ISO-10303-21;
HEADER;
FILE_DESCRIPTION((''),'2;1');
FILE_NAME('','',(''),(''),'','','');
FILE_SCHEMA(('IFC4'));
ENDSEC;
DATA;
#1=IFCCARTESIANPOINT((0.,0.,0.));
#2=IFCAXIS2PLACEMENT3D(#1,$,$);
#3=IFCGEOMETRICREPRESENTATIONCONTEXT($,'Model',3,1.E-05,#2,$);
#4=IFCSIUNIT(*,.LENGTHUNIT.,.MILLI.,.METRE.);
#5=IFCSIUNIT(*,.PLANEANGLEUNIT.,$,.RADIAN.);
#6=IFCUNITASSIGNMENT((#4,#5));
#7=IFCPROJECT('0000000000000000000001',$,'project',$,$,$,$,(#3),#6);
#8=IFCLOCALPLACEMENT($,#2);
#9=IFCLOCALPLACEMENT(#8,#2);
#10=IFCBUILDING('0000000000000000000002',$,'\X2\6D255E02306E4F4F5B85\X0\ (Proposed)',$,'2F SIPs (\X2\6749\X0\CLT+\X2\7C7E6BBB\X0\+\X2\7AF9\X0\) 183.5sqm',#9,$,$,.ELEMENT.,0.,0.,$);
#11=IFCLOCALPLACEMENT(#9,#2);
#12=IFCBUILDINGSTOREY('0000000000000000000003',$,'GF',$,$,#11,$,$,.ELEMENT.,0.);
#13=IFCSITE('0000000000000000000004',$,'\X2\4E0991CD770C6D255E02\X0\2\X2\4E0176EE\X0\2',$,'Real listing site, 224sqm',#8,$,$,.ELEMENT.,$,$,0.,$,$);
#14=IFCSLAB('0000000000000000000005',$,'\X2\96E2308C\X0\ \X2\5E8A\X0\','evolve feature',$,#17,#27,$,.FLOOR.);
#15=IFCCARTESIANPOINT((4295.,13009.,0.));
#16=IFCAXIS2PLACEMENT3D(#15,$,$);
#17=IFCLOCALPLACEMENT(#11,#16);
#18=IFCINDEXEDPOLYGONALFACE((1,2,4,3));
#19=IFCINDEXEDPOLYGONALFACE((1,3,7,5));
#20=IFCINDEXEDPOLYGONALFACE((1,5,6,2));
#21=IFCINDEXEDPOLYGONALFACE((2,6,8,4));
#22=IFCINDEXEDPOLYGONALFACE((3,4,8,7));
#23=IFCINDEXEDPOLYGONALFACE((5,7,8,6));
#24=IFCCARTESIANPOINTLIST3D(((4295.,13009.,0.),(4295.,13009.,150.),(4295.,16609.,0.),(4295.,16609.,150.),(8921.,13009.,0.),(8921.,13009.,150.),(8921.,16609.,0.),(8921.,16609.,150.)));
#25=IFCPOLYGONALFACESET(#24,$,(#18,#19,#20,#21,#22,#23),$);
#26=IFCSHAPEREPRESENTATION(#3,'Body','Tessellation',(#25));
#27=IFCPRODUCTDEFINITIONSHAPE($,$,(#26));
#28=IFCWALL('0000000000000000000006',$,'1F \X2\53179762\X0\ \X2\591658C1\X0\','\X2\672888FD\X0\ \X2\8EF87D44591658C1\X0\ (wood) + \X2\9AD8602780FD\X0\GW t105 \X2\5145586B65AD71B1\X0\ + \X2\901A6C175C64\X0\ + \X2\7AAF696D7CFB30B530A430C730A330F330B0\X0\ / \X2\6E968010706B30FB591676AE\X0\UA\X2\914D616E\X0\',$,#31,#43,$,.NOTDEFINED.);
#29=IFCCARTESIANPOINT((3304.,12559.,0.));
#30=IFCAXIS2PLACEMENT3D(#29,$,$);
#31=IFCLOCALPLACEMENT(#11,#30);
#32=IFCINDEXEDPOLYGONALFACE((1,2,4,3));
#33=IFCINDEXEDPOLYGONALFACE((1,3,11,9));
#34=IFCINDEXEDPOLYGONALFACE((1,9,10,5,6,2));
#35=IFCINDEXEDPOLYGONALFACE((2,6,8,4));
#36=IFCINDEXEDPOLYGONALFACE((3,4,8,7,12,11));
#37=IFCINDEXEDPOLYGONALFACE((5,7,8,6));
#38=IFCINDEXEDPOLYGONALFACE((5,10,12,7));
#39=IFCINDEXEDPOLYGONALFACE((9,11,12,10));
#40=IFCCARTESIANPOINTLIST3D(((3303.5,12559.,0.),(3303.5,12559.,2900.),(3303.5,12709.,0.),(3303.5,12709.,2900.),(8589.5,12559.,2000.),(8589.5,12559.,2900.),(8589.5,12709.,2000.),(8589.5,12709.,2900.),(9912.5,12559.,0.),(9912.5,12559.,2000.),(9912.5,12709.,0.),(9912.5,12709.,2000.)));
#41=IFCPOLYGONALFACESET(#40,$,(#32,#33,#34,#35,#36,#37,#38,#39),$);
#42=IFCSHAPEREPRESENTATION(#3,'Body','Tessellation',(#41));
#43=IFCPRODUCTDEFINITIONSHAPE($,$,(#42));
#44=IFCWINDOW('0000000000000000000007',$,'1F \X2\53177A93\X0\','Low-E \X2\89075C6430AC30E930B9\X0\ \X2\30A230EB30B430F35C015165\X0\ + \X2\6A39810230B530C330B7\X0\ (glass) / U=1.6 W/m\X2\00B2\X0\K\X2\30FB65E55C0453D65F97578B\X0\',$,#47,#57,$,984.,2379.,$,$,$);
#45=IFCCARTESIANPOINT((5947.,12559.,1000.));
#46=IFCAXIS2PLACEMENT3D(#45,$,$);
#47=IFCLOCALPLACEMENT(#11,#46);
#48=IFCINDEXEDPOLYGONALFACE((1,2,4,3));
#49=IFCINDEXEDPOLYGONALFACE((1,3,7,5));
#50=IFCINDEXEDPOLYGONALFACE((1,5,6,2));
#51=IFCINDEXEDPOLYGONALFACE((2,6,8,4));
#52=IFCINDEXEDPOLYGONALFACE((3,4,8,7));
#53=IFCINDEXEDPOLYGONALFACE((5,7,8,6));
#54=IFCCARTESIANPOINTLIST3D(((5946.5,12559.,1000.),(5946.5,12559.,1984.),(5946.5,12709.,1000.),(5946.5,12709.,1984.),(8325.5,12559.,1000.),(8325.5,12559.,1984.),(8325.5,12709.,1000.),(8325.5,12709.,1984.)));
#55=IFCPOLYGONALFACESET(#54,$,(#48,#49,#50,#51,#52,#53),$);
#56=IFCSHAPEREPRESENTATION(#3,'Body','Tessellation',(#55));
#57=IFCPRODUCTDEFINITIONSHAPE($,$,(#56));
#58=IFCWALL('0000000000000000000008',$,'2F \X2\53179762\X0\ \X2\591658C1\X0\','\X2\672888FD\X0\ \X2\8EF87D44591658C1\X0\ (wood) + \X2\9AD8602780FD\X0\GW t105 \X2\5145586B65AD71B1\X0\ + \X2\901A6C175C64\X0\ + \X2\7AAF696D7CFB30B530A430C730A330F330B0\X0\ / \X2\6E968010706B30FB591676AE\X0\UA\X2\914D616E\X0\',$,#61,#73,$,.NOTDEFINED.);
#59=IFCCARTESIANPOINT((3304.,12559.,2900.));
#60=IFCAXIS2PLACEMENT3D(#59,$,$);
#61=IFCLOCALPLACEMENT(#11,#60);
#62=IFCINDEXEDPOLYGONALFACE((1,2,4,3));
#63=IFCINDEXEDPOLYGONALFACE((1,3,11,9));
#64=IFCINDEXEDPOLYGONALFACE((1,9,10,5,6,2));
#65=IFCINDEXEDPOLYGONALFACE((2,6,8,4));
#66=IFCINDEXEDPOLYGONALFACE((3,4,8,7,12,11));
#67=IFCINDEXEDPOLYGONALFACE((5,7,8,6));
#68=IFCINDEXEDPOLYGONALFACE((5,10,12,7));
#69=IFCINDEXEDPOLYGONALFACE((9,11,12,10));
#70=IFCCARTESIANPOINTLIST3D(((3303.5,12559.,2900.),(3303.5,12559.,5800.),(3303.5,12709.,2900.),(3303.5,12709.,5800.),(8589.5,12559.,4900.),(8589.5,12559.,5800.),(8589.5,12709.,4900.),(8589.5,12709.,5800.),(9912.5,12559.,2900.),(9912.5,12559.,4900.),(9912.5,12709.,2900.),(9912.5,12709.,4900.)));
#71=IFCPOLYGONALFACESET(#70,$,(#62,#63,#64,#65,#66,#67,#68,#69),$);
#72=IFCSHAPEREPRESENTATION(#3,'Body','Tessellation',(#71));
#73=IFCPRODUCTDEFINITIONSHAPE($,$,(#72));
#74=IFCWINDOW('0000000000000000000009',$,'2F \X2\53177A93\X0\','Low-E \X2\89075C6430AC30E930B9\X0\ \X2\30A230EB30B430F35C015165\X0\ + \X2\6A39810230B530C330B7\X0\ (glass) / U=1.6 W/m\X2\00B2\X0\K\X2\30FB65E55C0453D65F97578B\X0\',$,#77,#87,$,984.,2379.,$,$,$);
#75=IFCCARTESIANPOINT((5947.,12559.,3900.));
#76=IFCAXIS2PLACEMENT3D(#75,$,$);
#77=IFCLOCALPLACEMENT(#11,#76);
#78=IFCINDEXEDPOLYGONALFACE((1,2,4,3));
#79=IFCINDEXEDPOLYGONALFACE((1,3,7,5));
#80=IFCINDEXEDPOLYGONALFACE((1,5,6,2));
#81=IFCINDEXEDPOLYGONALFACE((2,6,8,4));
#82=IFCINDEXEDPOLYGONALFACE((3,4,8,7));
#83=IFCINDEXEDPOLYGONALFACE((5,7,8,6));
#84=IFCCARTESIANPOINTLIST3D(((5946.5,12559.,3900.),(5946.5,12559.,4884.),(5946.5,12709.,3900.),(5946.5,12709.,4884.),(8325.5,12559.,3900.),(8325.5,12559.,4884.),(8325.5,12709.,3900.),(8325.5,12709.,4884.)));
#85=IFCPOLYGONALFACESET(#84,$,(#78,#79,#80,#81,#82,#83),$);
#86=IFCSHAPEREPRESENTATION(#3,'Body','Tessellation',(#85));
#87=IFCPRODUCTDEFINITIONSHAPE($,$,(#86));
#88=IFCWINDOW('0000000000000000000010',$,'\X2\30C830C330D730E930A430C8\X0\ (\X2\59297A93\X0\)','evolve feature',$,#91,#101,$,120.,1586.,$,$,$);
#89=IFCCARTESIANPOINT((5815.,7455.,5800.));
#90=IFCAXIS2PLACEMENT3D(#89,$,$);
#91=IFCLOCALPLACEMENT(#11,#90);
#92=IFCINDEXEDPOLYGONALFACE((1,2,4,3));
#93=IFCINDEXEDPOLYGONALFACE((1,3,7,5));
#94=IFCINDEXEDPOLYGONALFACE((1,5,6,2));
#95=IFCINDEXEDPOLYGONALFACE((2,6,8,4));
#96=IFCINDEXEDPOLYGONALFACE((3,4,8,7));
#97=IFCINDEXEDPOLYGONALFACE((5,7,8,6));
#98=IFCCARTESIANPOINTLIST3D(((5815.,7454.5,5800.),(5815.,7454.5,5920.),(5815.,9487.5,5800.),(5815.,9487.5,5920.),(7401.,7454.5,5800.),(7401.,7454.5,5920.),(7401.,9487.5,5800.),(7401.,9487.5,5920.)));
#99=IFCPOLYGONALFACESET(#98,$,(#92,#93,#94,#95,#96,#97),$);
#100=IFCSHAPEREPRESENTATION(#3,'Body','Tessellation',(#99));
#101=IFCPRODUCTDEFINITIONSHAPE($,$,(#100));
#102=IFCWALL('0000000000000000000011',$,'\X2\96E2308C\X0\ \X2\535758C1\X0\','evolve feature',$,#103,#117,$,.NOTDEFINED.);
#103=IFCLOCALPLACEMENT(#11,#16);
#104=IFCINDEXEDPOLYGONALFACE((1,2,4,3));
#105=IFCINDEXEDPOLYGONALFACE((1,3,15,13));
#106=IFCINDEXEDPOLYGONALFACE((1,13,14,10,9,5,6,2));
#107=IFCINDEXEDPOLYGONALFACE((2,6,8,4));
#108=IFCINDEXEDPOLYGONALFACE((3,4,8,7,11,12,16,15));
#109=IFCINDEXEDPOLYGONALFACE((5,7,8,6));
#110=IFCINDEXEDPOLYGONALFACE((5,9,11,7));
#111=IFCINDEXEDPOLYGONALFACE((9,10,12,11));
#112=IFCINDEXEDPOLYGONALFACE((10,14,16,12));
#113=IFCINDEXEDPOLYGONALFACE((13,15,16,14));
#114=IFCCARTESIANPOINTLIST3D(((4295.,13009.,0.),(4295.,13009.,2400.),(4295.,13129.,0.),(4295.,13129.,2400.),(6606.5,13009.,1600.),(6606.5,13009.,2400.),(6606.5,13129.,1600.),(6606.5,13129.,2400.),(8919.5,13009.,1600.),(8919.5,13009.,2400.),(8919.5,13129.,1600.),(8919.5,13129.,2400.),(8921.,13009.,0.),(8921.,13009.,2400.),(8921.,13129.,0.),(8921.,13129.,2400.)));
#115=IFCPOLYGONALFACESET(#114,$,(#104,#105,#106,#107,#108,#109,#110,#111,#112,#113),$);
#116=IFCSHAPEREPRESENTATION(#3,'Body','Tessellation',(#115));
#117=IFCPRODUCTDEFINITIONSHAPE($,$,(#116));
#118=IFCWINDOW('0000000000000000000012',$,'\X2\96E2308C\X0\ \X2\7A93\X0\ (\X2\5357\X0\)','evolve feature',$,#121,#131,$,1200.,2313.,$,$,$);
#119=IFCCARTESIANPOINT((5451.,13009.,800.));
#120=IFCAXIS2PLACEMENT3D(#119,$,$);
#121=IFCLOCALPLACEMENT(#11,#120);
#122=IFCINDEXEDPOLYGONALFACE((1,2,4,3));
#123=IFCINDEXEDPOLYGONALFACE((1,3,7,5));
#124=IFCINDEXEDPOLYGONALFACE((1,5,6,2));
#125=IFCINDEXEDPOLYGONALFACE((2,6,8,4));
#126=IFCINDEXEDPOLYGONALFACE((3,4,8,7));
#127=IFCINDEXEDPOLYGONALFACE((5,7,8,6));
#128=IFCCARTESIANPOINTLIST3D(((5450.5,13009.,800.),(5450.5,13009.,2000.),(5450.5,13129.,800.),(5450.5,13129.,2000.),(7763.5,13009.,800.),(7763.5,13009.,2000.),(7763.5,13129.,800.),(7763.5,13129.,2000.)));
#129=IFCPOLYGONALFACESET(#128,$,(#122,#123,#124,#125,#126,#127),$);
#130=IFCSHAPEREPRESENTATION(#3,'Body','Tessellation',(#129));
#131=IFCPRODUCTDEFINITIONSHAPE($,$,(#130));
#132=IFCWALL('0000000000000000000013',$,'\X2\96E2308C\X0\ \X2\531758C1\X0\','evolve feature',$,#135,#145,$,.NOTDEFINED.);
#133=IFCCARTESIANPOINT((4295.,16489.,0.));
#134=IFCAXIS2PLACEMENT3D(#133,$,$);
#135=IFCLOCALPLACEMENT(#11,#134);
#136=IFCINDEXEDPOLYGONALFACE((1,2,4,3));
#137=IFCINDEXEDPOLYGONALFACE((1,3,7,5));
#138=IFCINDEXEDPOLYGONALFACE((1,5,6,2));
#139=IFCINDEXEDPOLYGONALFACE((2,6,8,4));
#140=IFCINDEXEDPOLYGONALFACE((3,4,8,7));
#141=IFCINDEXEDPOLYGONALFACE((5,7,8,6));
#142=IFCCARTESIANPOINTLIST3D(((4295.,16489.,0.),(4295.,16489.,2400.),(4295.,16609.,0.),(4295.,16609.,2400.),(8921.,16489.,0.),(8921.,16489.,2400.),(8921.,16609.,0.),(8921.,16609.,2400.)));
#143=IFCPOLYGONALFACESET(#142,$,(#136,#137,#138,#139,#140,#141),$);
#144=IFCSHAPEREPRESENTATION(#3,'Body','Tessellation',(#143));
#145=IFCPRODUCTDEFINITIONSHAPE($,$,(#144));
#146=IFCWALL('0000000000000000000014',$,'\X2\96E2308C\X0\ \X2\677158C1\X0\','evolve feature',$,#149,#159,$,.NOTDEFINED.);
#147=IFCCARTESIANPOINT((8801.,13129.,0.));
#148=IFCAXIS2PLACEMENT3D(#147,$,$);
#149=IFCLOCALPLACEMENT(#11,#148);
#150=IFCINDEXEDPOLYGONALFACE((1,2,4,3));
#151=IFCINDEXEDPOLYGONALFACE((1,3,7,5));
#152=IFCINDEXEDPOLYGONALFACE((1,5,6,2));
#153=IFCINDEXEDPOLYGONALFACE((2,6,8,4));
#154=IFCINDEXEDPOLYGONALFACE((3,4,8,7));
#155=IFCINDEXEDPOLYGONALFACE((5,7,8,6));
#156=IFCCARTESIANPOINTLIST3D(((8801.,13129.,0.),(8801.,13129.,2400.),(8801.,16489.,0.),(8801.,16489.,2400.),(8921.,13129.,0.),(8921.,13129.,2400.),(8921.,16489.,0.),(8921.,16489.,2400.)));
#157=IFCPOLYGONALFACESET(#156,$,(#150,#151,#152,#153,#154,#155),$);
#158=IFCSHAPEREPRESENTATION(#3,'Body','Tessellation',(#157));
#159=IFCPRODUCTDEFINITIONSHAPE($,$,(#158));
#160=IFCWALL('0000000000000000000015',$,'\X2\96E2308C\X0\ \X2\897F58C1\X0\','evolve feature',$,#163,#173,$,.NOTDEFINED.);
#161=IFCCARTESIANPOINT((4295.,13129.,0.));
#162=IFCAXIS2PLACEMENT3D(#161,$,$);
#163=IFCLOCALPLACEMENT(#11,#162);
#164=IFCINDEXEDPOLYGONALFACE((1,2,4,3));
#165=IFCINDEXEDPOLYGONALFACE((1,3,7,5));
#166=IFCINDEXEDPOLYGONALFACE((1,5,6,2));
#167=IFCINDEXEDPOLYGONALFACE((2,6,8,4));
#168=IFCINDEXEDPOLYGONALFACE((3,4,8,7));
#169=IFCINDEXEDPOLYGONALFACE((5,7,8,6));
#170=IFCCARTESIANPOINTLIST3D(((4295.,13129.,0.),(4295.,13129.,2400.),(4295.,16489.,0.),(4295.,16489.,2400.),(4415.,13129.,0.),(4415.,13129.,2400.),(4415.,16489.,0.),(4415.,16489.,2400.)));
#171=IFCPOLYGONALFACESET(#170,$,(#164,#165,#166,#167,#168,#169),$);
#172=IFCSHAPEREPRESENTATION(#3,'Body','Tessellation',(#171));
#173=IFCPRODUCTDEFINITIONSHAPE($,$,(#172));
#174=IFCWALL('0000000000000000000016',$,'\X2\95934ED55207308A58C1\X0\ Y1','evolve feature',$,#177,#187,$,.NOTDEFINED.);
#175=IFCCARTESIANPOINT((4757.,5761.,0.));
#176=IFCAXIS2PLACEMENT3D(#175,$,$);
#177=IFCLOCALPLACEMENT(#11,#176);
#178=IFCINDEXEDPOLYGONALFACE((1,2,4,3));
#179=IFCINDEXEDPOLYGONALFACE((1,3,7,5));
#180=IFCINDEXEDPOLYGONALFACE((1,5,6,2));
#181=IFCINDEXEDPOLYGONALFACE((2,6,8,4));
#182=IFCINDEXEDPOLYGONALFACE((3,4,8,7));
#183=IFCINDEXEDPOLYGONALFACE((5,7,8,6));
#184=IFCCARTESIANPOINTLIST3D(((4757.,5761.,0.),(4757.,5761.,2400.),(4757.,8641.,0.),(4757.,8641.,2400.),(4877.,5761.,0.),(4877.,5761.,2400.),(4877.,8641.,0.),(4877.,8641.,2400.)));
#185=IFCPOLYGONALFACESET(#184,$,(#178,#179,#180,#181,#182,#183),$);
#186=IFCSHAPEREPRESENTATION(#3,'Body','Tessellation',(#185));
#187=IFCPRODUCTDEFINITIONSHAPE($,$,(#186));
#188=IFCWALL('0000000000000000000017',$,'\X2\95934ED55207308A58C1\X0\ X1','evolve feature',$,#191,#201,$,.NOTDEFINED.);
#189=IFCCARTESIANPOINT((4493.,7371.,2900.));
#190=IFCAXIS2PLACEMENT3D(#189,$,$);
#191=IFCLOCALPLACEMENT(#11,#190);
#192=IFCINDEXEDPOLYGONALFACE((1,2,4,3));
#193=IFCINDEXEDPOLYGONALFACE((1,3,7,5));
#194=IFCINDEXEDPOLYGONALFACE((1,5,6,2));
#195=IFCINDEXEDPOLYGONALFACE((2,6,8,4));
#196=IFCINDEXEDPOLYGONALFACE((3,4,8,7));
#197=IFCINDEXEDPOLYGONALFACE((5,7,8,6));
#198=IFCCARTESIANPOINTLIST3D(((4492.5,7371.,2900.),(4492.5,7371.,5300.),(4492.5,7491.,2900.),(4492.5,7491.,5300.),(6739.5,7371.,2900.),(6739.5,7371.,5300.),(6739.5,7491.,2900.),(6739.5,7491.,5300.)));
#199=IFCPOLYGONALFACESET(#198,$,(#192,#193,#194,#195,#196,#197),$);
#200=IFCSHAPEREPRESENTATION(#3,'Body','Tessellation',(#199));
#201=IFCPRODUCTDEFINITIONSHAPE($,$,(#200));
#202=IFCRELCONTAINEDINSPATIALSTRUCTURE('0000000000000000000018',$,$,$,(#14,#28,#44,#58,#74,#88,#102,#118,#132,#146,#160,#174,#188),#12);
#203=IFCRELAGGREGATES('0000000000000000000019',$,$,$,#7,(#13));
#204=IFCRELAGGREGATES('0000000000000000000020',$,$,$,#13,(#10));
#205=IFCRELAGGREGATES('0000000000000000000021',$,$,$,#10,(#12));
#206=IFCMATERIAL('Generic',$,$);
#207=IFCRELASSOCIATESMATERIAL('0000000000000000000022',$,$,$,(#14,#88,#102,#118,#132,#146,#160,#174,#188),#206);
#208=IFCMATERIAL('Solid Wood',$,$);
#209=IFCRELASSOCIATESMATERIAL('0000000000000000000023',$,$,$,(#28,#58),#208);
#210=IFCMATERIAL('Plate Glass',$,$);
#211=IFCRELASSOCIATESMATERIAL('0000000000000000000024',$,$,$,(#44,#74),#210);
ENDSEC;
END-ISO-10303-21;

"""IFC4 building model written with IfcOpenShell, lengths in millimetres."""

from ifc_helpers import new_model, si_unit, frame, frame_2d, origin, place, context, project, spatial, rectangle, extrude, material, element, fill, save


model = new_model("IFC4")

# Units and contexts
model_context = context("Model", 3, precision=1e-05, world=origin())
ifc_project = project(units=[si_unit("LENGTHUNIT", "METRE", prefix="MILLI"), si_unit("PLANEANGLEUNIT", "RADIAN")], contexts=[model_context])

# Site, building, storey
site_placement = place(None, origin())
site = spatial("IfcSite", under=ifc_project, at=site_placement, Name="三重県津市2丁目2", ObjectType="Real listing site, 224sqm", CompositionType="ELEMENT", RefElevation=0.0)
building_placement = place(site_placement, origin())
building = spatial("IfcBuilding", under=site, at=building_placement, Name="津市の住宅 (Proposed)", ObjectType="2F SIPs (杉CLT+籾殻+竹) 183.5sqm", CompositionType="ELEMENT", ElevationOfRefHeight=0.0, ElevationOfTerrain=0.0)
storey_placement = place(building_placement, origin())
storey = spatial("IfcBuildingStorey", under=building, at=storey_placement, Name="GF", CompositionType="ELEMENT", Elevation=0.0)

# Slab
ifc_material_1 = material(Name="Generic")
slab_placement = place(storey_placement, frame((4295.0, 13009.0, 0.0)))
element("IfcSlab", 1, at=slab_placement, inside=storey, material=ifc_material_1, Name="離れ 床", Description="evolve feature", PredefinedType="FLOOR", context=model_context, shape_type="SweptSolid", body=[
    extrude(rectangle(XDim=4626.0, YDim=3600.0, at=frame_2d((2313.0, 1800.0))), frame((4295.0, 13009.0, 0.0)), (0.0, 0.0, 1.0), 150.0),
])

# Wall, opening, window
ifc_material_2 = material(Name="Solid Wood")
wall_1_placement = place(storey_placement, frame((3304.0, 12559.0, 0.0)))
wall_1 = element("IfcWall", 2, at=wall_1_placement, inside=storey, material=ifc_material_2, Name="1F 北面 外壁", Description="木製 軸組外壁 (wood) + 高性能GW t105 充填断熱 + 通気層 + 窯業系サイディング / 準耐火・外皮UA配慮", PredefinedType="NOTDEFINED", context=model_context, shape_type="SweptSolid", body=[
    extrude(rectangle(XDim=6609.0, YDim=150.0, at=frame_2d((3304.0, 75.0))), frame((3304.0, 12559.0, 0.0)), (0.0, 0.0, 1.0), 2900.0),
])
opening_1_placement = place(storey_placement, frame((5947.0, 12559.0, 1000.0)))
opening_1 = element("IfcOpeningElement", 3, at=opening_1_placement, cuts=wall_1, PredefinedType="NOTDEFINED", context=model_context, shape_type="SweptSolid", body=[
    extrude(rectangle(XDim=2379.0, YDim=150.0, at=frame_2d((1189.0, 75.0))), frame((5947.0, 12559.0, 1000.0)), (0.0, 0.0, 1.0), 984.0),
])
ifc_material_3 = material(Name="Plate Glass")
window_1_placement = place(storey_placement, frame((5947.0, 12559.0, 1000.0)))
window_1 = element("IfcWindow", 4, at=window_1_placement, inside=storey, material=ifc_material_3, Name="1F 北窓", Description="Low-E 複層ガラス アルゴン封入 + 樹脂サッシ (glass) / U=1.6 W/m²K・日射取得型", OverallHeight=984.0, OverallWidth=2379.0, context=model_context, shape_type="SweptSolid", body=[
    extrude(rectangle(XDim=2379.0, YDim=150.0, at=frame_2d((1189.0, 75.0))), frame((5947.0, 12559.0, 1000.0)), (0.0, 0.0, 1.0), 984.0),
])
fill(opening_1, window_1)

# Wall, opening, window
wall_2_placement = place(storey_placement, frame((3304.0, 12559.0, 2900.0)))
wall_2 = element("IfcWall", 5, at=wall_2_placement, inside=storey, material=ifc_material_2, Name="2F 北面 外壁", Description="木製 軸組外壁 (wood) + 高性能GW t105 充填断熱 + 通気層 + 窯業系サイディング / 準耐火・外皮UA配慮", PredefinedType="NOTDEFINED", context=model_context, shape_type="SweptSolid", body=[
    extrude(rectangle(XDim=6609.0, YDim=150.0, at=frame_2d((3304.0, 75.0))), frame((3304.0, 12559.0, 2900.0)), (0.0, 0.0, 1.0), 2900.0),
])
opening_2_placement = place(storey_placement, frame((5947.0, 12559.0, 3900.0)))
opening_2 = element("IfcOpeningElement", 6, at=opening_2_placement, cuts=wall_2, PredefinedType="NOTDEFINED", context=model_context, shape_type="SweptSolid", body=[
    extrude(rectangle(XDim=2379.0, YDim=150.0, at=frame_2d((1189.0, 75.0))), frame((5947.0, 12559.0, 3900.0)), (0.0, 0.0, 1.0), 984.0),
])
window_2_placement = place(storey_placement, frame((5947.0, 12559.0, 3900.0)))
window_2 = element("IfcWindow", 7, at=window_2_placement, inside=storey, material=ifc_material_3, Name="2F 北窓", Description="Low-E 複層ガラス アルゴン封入 + 樹脂サッシ (glass) / U=1.6 W/m²K・日射取得型", OverallHeight=984.0, OverallWidth=2379.0, context=model_context, shape_type="SweptSolid", body=[
    extrude(rectangle(XDim=2379.0, YDim=150.0, at=frame_2d((1189.0, 75.0))), frame((5947.0, 12559.0, 3900.0)), (0.0, 0.0, 1.0), 984.0),
])
fill(opening_2, window_2)

# Window
window_3_placement = place(storey_placement, frame((5815.0, 7455.0, 5800.0)))
element("IfcWindow", 8, at=window_3_placement, inside=storey, material=ifc_material_1, Name="トップライト (天窓)", Description="evolve feature", OverallHeight=120.0, OverallWidth=1586.0, context=model_context, shape_type="SweptSolid", body=[
    extrude(rectangle(XDim=1586.0, YDim=2033.0, at=frame_2d((793.0, 1016.0))), frame((5815.0, 7455.0, 5800.0)), (0.0, 0.0, 1.0), 120.0),
])

# Wall, opening, window
wall_3_placement = place(storey_placement, frame((4295.0, 13009.0, 0.0)))
wall_3 = element("IfcWall", 9, at=wall_3_placement, inside=storey, material=ifc_material_1, Name="離れ 南壁", Description="evolve feature", PredefinedType="NOTDEFINED", context=model_context, shape_type="SweptSolid", body=[
    extrude(rectangle(XDim=4626.0, YDim=120.0, at=frame_2d((2313.0, 60.0))), frame((4295.0, 13009.0, 0.0)), (0.0, 0.0, 1.0), 2400.0),
])
opening_3_placement = place(storey_placement, frame((5451.0, 13009.0, 800.0)))
opening_3 = element("IfcOpeningElement", 10, at=opening_3_placement, cuts=wall_3, PredefinedType="NOTDEFINED", context=model_context, shape_type="SweptSolid", body=[
    extrude(rectangle(XDim=2313.0, YDim=120.0, at=frame_2d((1156.0, 60.0))), frame((5451.0, 13009.0, 800.0)), (0.0, 0.0, 1.0), 1200.0),
])
window_4_placement = place(storey_placement, frame((5451.0, 13009.0, 800.0)))
window_4 = element("IfcWindow", 11, at=window_4_placement, inside=storey, material=ifc_material_1, Name="離れ 窓 (南)", Description="evolve feature", OverallHeight=1200.0, OverallWidth=2313.0, context=model_context, shape_type="SweptSolid", body=[
    extrude(rectangle(XDim=2313.0, YDim=120.0, at=frame_2d((1156.0, 60.0))), frame((5451.0, 13009.0, 800.0)), (0.0, 0.0, 1.0), 1200.0),
])
fill(opening_3, window_4)

# Walls
wall_4_placement = place(storey_placement, frame((4295.0, 16489.0, 0.0)))
element("IfcWall", 12, at=wall_4_placement, inside=storey, material=ifc_material_1, Name="離れ 北壁", Description="evolve feature", PredefinedType="NOTDEFINED", context=model_context, shape_type="SweptSolid", body=[
    extrude(rectangle(XDim=4626.0, YDim=120.0, at=frame_2d((2313.0, 60.0))), frame((4295.0, 16489.0, 0.0)), (0.0, 0.0, 1.0), 2400.0),
])
wall_5_placement = place(storey_placement, frame((8801.0, 13129.0, 0.0)))
element("IfcWall", 13, at=wall_5_placement, inside=storey, material=ifc_material_1, Name="離れ 東壁", Description="evolve feature", PredefinedType="NOTDEFINED", context=model_context, shape_type="SweptSolid", body=[
    extrude(rectangle(XDim=120.0, YDim=3360.0, at=frame_2d((60.0, 1680.0))), frame((8801.0, 13129.0, 0.0)), (0.0, 0.0, 1.0), 2400.0),
])
wall_6_placement = place(storey_placement, frame((4295.0, 13129.0, 0.0)))
element("IfcWall", 14, at=wall_6_placement, inside=storey, material=ifc_material_1, Name="離れ 西壁", Description="evolve feature", PredefinedType="NOTDEFINED", context=model_context, shape_type="SweptSolid", body=[
    extrude(rectangle(XDim=120.0, YDim=3360.0, at=frame_2d((60.0, 1680.0))), frame((4295.0, 13129.0, 0.0)), (0.0, 0.0, 1.0), 2400.0),
])
wall_7_placement = place(storey_placement, frame((4757.0, 5761.0, 0.0)))
element("IfcWall", 15, at=wall_7_placement, inside=storey, material=ifc_material_1, Name="間仕切り壁 Y1", Description="evolve feature", PredefinedType="NOTDEFINED", context=model_context, shape_type="SweptSolid", body=[
    extrude(rectangle(XDim=120.0, YDim=2880.0, at=frame_2d((60.0, 1440.0))), frame((4757.0, 5761.0, 0.0)), (0.0, 0.0, 1.0), 2400.0),
])
wall_8_placement = place(storey_placement, frame((4493.0, 7371.0, 2900.0)))
element("IfcWall", 16, at=wall_8_placement, inside=storey, material=ifc_material_1, Name="間仕切り壁 X1", Description="evolve feature", PredefinedType="NOTDEFINED", context=model_context, shape_type="SweptSolid", body=[
    extrude(rectangle(XDim=2247.0, YDim=120.0, at=frame_2d((1123.0, 60.0))), frame((4493.0, 7371.0, 2900.0)), (0.0, 0.0, 1.0), 2400.0),
])

save(model, "model.ifc")
